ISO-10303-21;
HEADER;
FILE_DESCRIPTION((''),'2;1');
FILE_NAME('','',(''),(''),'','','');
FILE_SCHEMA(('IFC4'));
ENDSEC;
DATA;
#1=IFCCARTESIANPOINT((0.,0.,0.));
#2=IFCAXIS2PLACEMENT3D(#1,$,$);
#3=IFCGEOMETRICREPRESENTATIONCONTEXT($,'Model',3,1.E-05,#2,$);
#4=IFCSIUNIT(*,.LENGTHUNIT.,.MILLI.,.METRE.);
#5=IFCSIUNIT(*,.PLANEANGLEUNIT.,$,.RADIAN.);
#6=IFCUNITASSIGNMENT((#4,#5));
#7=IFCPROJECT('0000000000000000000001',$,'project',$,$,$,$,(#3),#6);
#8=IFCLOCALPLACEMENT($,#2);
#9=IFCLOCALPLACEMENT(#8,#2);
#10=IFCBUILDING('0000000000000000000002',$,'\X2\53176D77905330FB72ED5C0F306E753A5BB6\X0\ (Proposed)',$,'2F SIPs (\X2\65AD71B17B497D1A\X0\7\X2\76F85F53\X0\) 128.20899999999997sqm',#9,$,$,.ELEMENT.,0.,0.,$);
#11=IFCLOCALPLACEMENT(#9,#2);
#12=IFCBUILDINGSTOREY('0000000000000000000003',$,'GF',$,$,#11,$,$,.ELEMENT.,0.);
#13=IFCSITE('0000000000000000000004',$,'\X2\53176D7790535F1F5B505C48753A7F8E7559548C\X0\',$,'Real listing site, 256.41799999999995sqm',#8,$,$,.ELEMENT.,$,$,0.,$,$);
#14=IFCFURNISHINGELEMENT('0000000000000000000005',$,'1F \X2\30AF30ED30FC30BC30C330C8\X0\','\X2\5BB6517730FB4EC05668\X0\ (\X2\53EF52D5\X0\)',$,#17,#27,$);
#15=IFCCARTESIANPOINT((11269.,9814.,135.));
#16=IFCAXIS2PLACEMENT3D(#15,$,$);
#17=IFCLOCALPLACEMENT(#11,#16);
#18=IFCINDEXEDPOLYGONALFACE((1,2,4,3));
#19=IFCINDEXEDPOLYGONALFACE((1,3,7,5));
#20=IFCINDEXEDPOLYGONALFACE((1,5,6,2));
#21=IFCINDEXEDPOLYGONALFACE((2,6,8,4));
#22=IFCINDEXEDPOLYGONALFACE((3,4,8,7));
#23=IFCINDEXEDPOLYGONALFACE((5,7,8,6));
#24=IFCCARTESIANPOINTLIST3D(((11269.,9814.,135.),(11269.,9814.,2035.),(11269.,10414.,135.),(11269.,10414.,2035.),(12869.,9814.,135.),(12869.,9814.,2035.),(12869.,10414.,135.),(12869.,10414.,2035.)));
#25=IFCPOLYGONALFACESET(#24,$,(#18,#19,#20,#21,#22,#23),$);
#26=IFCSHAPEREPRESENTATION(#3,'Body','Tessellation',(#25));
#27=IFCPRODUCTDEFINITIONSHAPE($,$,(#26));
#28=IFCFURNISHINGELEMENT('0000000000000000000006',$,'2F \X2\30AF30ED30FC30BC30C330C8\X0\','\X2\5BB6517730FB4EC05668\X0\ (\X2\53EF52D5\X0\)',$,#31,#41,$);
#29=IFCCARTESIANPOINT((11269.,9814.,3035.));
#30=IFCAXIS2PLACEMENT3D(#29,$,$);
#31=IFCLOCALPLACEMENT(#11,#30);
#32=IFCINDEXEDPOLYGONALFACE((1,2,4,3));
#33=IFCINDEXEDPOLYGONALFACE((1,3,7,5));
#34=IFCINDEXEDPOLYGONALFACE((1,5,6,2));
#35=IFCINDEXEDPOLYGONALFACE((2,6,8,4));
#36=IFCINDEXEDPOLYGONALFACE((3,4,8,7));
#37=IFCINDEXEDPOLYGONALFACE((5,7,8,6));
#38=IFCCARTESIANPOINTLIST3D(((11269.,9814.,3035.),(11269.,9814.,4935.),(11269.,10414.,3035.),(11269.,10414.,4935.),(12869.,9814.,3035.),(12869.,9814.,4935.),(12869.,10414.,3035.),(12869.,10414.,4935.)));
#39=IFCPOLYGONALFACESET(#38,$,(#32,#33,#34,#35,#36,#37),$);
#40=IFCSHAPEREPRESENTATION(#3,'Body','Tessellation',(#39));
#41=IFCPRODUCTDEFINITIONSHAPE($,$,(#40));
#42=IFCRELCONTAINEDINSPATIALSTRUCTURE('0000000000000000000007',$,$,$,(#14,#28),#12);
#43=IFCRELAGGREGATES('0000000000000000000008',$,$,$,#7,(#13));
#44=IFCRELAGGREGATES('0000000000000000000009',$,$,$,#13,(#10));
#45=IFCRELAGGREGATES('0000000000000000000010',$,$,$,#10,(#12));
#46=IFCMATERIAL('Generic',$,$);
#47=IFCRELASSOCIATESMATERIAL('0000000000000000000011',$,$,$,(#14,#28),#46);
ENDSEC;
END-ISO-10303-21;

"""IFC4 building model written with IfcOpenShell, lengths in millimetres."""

from ifc_helpers import new_model, si_unit, frame, frame_2d, origin, place, context, project, spatial, rectangle, extrude, material, element, save


model = new_model("IFC4")

# Units and contexts
model_context = context("Model", 3, precision=1e-05, world=origin())
ifc_project = project(units=[si_unit("LENGTHUNIT", "METRE", prefix="MILLI"), si_unit("PLANEANGLEUNIT", "RADIAN")], contexts=[model_context])

# Site, building, storey
site_placement = place(None, origin())
site = spatial("IfcSite", under=ifc_project, at=site_placement, Name="北海道弟子屈町美留和", ObjectType="Real listing site, 256.41799999999995sqm", CompositionType="ELEMENT", RefElevation=0.0)
building_placement = place(site_placement, origin())
building = spatial("IfcBuilding", under=site, at=building_placement, Name="北海道・狭小の町家 (Proposed)", ObjectType="2F SIPs (断熱等級7相当) 128.20899999999997sqm", CompositionType="ELEMENT", ElevationOfRefHeight=0.0, ElevationOfTerrain=0.0)
storey_placement = place(building_placement, origin())
storey = spatial("IfcBuildingStorey", under=building, at=storey_placement, Name="GF", CompositionType="ELEMENT", Elevation=0.0)

# Shared definitions
ifc_material_1 = material(Name="Generic")

# Furnishing elements
furnishing_1_placement = place(storey_placement, frame((11269.0, 9814.0, 135.0)))
element("IfcFurnishingElement", 1, at=furnishing_1_placement, inside=storey, material=ifc_material_1, Name="1F クローゼット", Description="家具・什器 (可動)", context=model_context, shape_type="SweptSolid", body=[
    extrude(rectangle(XDim=1600.0, YDim=600.0, at=frame_2d((800.0, 300.0))), frame((11269.0, 9814.0, 135.0)), (0.0, 0.0, 1.0), 1900.0),
])
furnishing_2_placement = place(storey_placement, frame((11269.0, 9814.0, 3035.0)))
element("IfcFurnishingElement", 2, at=furnishing_2_placement, inside=storey, material=ifc_material_1, Name="2F クローゼット", Description="家具・什器 (可動)", context=model_context, shape_type="SweptSolid", body=[
    extrude(rectangle(XDim=1600.0, YDim=600.0, at=frame_2d((800.0, 300.0))), frame((11269.0, 9814.0, 3035.0)), (0.0, 0.0, 1.0), 1900.0),
])

save(model, "model.ifc")
